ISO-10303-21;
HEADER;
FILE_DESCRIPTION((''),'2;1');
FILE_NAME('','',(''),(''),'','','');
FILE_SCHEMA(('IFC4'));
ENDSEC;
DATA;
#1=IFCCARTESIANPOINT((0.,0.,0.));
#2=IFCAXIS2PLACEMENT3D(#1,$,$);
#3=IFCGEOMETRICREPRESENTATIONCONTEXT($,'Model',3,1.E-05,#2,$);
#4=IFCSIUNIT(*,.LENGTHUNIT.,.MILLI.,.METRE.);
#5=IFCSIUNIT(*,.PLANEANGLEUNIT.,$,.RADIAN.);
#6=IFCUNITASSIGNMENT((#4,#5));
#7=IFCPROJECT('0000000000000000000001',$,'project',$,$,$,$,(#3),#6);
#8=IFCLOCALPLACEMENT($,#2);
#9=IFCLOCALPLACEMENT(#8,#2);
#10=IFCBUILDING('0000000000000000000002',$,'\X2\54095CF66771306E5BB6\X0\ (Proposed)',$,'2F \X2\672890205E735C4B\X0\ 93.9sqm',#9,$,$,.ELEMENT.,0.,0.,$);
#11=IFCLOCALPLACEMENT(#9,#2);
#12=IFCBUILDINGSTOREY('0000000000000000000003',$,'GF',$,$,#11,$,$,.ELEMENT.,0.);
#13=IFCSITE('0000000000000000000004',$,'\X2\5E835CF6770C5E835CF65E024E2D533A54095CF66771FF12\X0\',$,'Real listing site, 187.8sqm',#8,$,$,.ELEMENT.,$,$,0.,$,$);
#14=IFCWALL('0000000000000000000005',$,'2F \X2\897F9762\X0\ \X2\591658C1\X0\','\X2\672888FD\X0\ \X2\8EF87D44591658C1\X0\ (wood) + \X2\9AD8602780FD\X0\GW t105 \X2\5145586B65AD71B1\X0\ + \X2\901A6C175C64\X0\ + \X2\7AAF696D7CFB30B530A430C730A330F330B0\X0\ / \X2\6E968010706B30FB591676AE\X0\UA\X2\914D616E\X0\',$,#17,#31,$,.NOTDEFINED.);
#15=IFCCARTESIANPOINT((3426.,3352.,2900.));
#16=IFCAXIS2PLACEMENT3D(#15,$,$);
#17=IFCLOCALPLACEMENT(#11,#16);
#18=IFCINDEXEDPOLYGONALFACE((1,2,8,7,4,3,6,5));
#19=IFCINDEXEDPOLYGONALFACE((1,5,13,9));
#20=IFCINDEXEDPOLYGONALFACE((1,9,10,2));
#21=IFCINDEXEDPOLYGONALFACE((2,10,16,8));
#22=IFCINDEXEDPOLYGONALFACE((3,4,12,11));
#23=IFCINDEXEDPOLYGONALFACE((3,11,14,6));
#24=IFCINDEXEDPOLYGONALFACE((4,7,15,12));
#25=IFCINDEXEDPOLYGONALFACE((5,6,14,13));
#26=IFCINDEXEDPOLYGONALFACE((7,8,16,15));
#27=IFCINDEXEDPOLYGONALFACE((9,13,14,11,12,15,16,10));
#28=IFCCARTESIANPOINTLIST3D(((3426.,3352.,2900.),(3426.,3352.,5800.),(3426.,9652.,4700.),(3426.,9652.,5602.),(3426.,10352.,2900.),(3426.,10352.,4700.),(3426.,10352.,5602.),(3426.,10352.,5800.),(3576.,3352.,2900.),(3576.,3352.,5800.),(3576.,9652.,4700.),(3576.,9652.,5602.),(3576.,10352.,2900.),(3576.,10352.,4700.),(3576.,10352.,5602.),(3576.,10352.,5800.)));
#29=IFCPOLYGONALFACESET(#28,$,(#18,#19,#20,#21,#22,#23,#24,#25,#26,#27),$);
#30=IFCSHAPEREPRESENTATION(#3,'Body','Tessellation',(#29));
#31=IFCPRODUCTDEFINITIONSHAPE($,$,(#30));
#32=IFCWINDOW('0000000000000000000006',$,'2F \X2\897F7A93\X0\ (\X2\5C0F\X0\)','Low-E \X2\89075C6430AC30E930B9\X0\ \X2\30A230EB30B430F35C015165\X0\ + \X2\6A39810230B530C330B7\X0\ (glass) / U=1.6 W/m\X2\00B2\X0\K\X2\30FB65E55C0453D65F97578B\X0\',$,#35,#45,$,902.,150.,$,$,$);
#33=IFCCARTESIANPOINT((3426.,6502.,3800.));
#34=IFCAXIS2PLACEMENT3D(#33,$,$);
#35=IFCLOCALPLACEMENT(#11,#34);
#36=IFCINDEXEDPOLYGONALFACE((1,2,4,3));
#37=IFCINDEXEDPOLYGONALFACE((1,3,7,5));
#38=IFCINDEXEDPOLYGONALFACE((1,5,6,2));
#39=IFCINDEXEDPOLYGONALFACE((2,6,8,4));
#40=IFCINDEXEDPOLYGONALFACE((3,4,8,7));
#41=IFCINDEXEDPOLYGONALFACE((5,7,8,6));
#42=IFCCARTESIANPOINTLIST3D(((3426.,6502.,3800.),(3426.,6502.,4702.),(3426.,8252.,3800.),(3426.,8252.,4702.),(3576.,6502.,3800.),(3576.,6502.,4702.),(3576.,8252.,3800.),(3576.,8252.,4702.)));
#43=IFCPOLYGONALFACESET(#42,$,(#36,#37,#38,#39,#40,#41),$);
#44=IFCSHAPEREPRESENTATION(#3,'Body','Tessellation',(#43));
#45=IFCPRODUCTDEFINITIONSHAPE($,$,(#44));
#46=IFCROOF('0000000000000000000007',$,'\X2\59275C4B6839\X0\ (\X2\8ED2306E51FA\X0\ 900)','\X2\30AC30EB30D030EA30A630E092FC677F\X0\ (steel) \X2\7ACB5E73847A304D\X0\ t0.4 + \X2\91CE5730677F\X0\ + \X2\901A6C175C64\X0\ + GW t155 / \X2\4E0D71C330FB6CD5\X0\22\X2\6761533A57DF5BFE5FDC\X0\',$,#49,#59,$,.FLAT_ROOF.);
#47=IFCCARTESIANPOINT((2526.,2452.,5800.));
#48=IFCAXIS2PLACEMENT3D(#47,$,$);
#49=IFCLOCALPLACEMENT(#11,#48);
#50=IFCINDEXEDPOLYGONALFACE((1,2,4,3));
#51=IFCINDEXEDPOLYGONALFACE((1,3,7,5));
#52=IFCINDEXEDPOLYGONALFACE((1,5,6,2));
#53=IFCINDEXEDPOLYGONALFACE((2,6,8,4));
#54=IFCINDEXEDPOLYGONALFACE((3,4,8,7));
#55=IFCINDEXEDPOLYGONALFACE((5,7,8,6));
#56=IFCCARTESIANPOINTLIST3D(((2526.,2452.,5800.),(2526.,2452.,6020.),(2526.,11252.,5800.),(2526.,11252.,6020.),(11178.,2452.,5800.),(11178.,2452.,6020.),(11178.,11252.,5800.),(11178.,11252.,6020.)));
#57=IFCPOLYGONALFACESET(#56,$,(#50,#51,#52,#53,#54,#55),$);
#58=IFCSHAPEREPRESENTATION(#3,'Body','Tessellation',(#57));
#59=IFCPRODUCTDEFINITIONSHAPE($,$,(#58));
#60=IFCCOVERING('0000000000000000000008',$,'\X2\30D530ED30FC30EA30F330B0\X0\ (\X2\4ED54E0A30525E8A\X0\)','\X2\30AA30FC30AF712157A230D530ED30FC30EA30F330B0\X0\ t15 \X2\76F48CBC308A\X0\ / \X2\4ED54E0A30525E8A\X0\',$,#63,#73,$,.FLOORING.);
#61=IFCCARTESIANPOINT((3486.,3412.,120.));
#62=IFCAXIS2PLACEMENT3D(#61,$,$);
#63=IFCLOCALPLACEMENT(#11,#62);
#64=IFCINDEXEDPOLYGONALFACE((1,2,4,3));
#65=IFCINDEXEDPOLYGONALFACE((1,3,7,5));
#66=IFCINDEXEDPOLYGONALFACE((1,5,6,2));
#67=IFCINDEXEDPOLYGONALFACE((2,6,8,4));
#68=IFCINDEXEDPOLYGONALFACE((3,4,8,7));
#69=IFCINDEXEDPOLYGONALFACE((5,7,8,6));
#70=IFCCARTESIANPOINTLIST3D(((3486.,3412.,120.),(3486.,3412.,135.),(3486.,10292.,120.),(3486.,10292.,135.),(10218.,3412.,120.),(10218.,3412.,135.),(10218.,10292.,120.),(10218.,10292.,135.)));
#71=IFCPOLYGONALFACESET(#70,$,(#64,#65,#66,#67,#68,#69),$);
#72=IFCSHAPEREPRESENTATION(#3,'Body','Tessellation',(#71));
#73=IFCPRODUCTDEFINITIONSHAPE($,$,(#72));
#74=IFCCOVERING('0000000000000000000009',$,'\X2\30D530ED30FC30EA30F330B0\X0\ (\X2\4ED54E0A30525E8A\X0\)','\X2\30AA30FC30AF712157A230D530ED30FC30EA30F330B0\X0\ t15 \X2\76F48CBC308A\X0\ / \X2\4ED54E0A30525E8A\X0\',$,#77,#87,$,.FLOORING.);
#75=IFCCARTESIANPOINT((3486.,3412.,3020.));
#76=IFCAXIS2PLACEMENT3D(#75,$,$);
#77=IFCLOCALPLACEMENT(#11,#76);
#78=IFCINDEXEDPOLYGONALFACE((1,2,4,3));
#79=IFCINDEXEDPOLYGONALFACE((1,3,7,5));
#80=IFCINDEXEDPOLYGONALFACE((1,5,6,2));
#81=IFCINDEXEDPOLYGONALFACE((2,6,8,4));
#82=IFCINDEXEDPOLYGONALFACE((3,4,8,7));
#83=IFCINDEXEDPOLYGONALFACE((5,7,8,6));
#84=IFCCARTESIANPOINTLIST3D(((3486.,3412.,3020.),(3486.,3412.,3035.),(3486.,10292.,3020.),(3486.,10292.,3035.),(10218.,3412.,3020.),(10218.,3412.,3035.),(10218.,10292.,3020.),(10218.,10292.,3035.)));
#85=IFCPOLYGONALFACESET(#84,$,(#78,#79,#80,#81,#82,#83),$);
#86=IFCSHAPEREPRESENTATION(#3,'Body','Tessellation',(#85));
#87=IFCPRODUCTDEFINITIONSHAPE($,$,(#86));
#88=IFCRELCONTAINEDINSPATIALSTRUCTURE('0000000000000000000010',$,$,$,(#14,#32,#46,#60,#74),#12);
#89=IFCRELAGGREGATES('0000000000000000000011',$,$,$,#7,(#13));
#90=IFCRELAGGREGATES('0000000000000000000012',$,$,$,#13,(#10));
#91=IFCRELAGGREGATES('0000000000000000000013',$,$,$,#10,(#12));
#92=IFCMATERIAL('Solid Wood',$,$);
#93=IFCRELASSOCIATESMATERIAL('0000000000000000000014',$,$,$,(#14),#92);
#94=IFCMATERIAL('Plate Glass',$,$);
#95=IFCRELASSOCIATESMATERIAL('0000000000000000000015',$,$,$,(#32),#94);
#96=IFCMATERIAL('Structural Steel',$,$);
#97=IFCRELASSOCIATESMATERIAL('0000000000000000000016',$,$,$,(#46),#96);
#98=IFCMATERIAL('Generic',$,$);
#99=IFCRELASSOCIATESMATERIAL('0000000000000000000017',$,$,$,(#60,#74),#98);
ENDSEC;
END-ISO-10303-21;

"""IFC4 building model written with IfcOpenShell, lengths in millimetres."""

from ifc_helpers import new_model, si_unit, frame, frame_2d, origin, place, context, project, spatial, rectangle, extrude, material, element, fill, save


model = new_model("IFC4")

# Units and contexts
model_context = context("Model", 3, precision=1e-05, world=origin())
ifc_project = project(units=[si_unit("LENGTHUNIT", "METRE", prefix="MILLI"), si_unit("PLANEANGLEUNIT", "RADIAN")], contexts=[model_context])

# Site, building, storey
site_placement = place(None, origin())
site = spatial("IfcSite", under=ifc_project, at=site_placement, Name="広島県広島市中区吉島東２", ObjectType="Real listing site, 187.8sqm", CompositionType="ELEMENT", RefElevation=0.0)
building_placement = place(site_placement, origin())
building = spatial("IfcBuilding", under=site, at=building_placement, Name="吉島東の家 (Proposed)", ObjectType="2F 木造平屋 93.9sqm", CompositionType="ELEMENT", ElevationOfRefHeight=0.0, ElevationOfTerrain=0.0)
storey_placement = place(building_placement, origin())
storey = spatial("IfcBuildingStorey", under=building, at=storey_placement, Name="GF", CompositionType="ELEMENT", Elevation=0.0)

# Shared definitions
ifc_material_1 = material(Name="Solid Wood")

# Shared definitions
ifc_material_2 = material(Name="Plate Glass")

# Wall, opening, window
wall_1_placement = place(storey_placement, frame((3426.0, 3352.0, 2900.0)))
wall_1 = element("IfcWall", 1, at=wall_1_placement, inside=storey, material=ifc_material_1, Name="2F 西面 外壁", Description="木製 軸組外壁 (wood) + 高性能GW t105 充填断熱 + 通気層 + 窯業系サイディング / 準耐火・外皮UA配慮", PredefinedType="NOTDEFINED", context=model_context, shape_type="SweptSolid", body=[
    extrude(rectangle(XDim=150.0, YDim=7000.0, at=frame_2d((75.0, 3500.0))), frame((3426.0, 3352.0, 2900.0)), (0.0, 0.0, 1.0), 2900.0),
])
opening_1_placement = place(storey_placement, frame((3426.0, 6502.0, 3800.0)))
opening_1 = element("IfcOpeningElement", 2, at=opening_1_placement, cuts=wall_1, PredefinedType="NOTDEFINED", context=model_context, shape_type="SweptSolid", body=[
    extrude(rectangle(XDim=150.0, YDim=1750.0, at=frame_2d((75.0, 875.0))), frame((3426.0, 6502.0, 3800.0)), (0.0, 0.0, 1.0), 902.0),
])
window_1_placement = place(storey_placement, frame((3426.0, 6502.0, 3800.0)))
window_1 = element("IfcWindow", 3, at=window_1_placement, inside=storey, material=ifc_material_2, Name="2F 西窓 (小)", Description="Low-E 複層ガラス アルゴン封入 + 樹脂サッシ (glass) / U=1.6 W/m²K・日射取得型", OverallHeight=902.0, OverallWidth=150.0, context=model_context, shape_type="SweptSolid", body=[
    extrude(rectangle(XDim=150.0, YDim=1750.0, at=frame_2d((75.0, 875.0))), frame((3426.0, 6502.0, 3800.0)), (0.0, 0.0, 1.0), 902.0),
])
fill(opening_1, window_1)

# Roof
ifc_material_3 = material(Name="Structural Steel")
roof_placement = place(storey_placement, frame((2526.0, 2452.0, 5800.0)))
element("IfcRoof", 4, at=roof_placement, inside=storey, material=ifc_material_3, Name="大屋根 (軒の出 900)", Description="ガルバリウム鋼板 (steel) 立平葺き t0.4 + 野地板 + 通気層 + GW t155 / 不燃・法22条区域対応", PredefinedType="FLAT_ROOF", context=model_context, shape_type="SweptSolid", body=[
    extrude(rectangle(XDim=8652.0, YDim=8800.0, at=frame_2d((4326.0, 4400.0))), frame((2526.0, 2452.0, 5800.0)), (0.0, 0.0, 1.0), 220.0),
])

# Coverings
ifc_material_4 = material(Name="Generic")
covering_1_placement = place(storey_placement, frame((3486.0, 3412.0, 120.0)))
element("IfcCovering", 5, at=covering_1_placement, inside=storey, material=ifc_material_4, Name="フローリング (仕上げ床)", Description="オーク無垢フローリング t15 直貼り / 仕上げ床", PredefinedType="FLOORING", context=model_context, shape_type="SweptSolid", body=[
    extrude(rectangle(XDim=6732.0, YDim=6880.0, at=frame_2d((3366.0, 3440.0))), frame((3486.0, 3412.0, 120.0)), (0.0, 0.0, 1.0), 15.0),
])
covering_2_placement = place(storey_placement, frame((3486.0, 3412.0, 3020.0)))
element("IfcCovering", 6, at=covering_2_placement, inside=storey, material=ifc_material_4, Name="フローリング (仕上げ床)", Description="オーク無垢フローリング t15 直貼り / 仕上げ床", PredefinedType="FLOORING", context=model_context, shape_type="SweptSolid", body=[
    extrude(rectangle(XDim=6732.0, YDim=6880.0, at=frame_2d((3366.0, 3440.0))), frame((3486.0, 3412.0, 3020.0)), (0.0, 0.0, 1.0), 15.0),
])

save(model, "model.ifc")
